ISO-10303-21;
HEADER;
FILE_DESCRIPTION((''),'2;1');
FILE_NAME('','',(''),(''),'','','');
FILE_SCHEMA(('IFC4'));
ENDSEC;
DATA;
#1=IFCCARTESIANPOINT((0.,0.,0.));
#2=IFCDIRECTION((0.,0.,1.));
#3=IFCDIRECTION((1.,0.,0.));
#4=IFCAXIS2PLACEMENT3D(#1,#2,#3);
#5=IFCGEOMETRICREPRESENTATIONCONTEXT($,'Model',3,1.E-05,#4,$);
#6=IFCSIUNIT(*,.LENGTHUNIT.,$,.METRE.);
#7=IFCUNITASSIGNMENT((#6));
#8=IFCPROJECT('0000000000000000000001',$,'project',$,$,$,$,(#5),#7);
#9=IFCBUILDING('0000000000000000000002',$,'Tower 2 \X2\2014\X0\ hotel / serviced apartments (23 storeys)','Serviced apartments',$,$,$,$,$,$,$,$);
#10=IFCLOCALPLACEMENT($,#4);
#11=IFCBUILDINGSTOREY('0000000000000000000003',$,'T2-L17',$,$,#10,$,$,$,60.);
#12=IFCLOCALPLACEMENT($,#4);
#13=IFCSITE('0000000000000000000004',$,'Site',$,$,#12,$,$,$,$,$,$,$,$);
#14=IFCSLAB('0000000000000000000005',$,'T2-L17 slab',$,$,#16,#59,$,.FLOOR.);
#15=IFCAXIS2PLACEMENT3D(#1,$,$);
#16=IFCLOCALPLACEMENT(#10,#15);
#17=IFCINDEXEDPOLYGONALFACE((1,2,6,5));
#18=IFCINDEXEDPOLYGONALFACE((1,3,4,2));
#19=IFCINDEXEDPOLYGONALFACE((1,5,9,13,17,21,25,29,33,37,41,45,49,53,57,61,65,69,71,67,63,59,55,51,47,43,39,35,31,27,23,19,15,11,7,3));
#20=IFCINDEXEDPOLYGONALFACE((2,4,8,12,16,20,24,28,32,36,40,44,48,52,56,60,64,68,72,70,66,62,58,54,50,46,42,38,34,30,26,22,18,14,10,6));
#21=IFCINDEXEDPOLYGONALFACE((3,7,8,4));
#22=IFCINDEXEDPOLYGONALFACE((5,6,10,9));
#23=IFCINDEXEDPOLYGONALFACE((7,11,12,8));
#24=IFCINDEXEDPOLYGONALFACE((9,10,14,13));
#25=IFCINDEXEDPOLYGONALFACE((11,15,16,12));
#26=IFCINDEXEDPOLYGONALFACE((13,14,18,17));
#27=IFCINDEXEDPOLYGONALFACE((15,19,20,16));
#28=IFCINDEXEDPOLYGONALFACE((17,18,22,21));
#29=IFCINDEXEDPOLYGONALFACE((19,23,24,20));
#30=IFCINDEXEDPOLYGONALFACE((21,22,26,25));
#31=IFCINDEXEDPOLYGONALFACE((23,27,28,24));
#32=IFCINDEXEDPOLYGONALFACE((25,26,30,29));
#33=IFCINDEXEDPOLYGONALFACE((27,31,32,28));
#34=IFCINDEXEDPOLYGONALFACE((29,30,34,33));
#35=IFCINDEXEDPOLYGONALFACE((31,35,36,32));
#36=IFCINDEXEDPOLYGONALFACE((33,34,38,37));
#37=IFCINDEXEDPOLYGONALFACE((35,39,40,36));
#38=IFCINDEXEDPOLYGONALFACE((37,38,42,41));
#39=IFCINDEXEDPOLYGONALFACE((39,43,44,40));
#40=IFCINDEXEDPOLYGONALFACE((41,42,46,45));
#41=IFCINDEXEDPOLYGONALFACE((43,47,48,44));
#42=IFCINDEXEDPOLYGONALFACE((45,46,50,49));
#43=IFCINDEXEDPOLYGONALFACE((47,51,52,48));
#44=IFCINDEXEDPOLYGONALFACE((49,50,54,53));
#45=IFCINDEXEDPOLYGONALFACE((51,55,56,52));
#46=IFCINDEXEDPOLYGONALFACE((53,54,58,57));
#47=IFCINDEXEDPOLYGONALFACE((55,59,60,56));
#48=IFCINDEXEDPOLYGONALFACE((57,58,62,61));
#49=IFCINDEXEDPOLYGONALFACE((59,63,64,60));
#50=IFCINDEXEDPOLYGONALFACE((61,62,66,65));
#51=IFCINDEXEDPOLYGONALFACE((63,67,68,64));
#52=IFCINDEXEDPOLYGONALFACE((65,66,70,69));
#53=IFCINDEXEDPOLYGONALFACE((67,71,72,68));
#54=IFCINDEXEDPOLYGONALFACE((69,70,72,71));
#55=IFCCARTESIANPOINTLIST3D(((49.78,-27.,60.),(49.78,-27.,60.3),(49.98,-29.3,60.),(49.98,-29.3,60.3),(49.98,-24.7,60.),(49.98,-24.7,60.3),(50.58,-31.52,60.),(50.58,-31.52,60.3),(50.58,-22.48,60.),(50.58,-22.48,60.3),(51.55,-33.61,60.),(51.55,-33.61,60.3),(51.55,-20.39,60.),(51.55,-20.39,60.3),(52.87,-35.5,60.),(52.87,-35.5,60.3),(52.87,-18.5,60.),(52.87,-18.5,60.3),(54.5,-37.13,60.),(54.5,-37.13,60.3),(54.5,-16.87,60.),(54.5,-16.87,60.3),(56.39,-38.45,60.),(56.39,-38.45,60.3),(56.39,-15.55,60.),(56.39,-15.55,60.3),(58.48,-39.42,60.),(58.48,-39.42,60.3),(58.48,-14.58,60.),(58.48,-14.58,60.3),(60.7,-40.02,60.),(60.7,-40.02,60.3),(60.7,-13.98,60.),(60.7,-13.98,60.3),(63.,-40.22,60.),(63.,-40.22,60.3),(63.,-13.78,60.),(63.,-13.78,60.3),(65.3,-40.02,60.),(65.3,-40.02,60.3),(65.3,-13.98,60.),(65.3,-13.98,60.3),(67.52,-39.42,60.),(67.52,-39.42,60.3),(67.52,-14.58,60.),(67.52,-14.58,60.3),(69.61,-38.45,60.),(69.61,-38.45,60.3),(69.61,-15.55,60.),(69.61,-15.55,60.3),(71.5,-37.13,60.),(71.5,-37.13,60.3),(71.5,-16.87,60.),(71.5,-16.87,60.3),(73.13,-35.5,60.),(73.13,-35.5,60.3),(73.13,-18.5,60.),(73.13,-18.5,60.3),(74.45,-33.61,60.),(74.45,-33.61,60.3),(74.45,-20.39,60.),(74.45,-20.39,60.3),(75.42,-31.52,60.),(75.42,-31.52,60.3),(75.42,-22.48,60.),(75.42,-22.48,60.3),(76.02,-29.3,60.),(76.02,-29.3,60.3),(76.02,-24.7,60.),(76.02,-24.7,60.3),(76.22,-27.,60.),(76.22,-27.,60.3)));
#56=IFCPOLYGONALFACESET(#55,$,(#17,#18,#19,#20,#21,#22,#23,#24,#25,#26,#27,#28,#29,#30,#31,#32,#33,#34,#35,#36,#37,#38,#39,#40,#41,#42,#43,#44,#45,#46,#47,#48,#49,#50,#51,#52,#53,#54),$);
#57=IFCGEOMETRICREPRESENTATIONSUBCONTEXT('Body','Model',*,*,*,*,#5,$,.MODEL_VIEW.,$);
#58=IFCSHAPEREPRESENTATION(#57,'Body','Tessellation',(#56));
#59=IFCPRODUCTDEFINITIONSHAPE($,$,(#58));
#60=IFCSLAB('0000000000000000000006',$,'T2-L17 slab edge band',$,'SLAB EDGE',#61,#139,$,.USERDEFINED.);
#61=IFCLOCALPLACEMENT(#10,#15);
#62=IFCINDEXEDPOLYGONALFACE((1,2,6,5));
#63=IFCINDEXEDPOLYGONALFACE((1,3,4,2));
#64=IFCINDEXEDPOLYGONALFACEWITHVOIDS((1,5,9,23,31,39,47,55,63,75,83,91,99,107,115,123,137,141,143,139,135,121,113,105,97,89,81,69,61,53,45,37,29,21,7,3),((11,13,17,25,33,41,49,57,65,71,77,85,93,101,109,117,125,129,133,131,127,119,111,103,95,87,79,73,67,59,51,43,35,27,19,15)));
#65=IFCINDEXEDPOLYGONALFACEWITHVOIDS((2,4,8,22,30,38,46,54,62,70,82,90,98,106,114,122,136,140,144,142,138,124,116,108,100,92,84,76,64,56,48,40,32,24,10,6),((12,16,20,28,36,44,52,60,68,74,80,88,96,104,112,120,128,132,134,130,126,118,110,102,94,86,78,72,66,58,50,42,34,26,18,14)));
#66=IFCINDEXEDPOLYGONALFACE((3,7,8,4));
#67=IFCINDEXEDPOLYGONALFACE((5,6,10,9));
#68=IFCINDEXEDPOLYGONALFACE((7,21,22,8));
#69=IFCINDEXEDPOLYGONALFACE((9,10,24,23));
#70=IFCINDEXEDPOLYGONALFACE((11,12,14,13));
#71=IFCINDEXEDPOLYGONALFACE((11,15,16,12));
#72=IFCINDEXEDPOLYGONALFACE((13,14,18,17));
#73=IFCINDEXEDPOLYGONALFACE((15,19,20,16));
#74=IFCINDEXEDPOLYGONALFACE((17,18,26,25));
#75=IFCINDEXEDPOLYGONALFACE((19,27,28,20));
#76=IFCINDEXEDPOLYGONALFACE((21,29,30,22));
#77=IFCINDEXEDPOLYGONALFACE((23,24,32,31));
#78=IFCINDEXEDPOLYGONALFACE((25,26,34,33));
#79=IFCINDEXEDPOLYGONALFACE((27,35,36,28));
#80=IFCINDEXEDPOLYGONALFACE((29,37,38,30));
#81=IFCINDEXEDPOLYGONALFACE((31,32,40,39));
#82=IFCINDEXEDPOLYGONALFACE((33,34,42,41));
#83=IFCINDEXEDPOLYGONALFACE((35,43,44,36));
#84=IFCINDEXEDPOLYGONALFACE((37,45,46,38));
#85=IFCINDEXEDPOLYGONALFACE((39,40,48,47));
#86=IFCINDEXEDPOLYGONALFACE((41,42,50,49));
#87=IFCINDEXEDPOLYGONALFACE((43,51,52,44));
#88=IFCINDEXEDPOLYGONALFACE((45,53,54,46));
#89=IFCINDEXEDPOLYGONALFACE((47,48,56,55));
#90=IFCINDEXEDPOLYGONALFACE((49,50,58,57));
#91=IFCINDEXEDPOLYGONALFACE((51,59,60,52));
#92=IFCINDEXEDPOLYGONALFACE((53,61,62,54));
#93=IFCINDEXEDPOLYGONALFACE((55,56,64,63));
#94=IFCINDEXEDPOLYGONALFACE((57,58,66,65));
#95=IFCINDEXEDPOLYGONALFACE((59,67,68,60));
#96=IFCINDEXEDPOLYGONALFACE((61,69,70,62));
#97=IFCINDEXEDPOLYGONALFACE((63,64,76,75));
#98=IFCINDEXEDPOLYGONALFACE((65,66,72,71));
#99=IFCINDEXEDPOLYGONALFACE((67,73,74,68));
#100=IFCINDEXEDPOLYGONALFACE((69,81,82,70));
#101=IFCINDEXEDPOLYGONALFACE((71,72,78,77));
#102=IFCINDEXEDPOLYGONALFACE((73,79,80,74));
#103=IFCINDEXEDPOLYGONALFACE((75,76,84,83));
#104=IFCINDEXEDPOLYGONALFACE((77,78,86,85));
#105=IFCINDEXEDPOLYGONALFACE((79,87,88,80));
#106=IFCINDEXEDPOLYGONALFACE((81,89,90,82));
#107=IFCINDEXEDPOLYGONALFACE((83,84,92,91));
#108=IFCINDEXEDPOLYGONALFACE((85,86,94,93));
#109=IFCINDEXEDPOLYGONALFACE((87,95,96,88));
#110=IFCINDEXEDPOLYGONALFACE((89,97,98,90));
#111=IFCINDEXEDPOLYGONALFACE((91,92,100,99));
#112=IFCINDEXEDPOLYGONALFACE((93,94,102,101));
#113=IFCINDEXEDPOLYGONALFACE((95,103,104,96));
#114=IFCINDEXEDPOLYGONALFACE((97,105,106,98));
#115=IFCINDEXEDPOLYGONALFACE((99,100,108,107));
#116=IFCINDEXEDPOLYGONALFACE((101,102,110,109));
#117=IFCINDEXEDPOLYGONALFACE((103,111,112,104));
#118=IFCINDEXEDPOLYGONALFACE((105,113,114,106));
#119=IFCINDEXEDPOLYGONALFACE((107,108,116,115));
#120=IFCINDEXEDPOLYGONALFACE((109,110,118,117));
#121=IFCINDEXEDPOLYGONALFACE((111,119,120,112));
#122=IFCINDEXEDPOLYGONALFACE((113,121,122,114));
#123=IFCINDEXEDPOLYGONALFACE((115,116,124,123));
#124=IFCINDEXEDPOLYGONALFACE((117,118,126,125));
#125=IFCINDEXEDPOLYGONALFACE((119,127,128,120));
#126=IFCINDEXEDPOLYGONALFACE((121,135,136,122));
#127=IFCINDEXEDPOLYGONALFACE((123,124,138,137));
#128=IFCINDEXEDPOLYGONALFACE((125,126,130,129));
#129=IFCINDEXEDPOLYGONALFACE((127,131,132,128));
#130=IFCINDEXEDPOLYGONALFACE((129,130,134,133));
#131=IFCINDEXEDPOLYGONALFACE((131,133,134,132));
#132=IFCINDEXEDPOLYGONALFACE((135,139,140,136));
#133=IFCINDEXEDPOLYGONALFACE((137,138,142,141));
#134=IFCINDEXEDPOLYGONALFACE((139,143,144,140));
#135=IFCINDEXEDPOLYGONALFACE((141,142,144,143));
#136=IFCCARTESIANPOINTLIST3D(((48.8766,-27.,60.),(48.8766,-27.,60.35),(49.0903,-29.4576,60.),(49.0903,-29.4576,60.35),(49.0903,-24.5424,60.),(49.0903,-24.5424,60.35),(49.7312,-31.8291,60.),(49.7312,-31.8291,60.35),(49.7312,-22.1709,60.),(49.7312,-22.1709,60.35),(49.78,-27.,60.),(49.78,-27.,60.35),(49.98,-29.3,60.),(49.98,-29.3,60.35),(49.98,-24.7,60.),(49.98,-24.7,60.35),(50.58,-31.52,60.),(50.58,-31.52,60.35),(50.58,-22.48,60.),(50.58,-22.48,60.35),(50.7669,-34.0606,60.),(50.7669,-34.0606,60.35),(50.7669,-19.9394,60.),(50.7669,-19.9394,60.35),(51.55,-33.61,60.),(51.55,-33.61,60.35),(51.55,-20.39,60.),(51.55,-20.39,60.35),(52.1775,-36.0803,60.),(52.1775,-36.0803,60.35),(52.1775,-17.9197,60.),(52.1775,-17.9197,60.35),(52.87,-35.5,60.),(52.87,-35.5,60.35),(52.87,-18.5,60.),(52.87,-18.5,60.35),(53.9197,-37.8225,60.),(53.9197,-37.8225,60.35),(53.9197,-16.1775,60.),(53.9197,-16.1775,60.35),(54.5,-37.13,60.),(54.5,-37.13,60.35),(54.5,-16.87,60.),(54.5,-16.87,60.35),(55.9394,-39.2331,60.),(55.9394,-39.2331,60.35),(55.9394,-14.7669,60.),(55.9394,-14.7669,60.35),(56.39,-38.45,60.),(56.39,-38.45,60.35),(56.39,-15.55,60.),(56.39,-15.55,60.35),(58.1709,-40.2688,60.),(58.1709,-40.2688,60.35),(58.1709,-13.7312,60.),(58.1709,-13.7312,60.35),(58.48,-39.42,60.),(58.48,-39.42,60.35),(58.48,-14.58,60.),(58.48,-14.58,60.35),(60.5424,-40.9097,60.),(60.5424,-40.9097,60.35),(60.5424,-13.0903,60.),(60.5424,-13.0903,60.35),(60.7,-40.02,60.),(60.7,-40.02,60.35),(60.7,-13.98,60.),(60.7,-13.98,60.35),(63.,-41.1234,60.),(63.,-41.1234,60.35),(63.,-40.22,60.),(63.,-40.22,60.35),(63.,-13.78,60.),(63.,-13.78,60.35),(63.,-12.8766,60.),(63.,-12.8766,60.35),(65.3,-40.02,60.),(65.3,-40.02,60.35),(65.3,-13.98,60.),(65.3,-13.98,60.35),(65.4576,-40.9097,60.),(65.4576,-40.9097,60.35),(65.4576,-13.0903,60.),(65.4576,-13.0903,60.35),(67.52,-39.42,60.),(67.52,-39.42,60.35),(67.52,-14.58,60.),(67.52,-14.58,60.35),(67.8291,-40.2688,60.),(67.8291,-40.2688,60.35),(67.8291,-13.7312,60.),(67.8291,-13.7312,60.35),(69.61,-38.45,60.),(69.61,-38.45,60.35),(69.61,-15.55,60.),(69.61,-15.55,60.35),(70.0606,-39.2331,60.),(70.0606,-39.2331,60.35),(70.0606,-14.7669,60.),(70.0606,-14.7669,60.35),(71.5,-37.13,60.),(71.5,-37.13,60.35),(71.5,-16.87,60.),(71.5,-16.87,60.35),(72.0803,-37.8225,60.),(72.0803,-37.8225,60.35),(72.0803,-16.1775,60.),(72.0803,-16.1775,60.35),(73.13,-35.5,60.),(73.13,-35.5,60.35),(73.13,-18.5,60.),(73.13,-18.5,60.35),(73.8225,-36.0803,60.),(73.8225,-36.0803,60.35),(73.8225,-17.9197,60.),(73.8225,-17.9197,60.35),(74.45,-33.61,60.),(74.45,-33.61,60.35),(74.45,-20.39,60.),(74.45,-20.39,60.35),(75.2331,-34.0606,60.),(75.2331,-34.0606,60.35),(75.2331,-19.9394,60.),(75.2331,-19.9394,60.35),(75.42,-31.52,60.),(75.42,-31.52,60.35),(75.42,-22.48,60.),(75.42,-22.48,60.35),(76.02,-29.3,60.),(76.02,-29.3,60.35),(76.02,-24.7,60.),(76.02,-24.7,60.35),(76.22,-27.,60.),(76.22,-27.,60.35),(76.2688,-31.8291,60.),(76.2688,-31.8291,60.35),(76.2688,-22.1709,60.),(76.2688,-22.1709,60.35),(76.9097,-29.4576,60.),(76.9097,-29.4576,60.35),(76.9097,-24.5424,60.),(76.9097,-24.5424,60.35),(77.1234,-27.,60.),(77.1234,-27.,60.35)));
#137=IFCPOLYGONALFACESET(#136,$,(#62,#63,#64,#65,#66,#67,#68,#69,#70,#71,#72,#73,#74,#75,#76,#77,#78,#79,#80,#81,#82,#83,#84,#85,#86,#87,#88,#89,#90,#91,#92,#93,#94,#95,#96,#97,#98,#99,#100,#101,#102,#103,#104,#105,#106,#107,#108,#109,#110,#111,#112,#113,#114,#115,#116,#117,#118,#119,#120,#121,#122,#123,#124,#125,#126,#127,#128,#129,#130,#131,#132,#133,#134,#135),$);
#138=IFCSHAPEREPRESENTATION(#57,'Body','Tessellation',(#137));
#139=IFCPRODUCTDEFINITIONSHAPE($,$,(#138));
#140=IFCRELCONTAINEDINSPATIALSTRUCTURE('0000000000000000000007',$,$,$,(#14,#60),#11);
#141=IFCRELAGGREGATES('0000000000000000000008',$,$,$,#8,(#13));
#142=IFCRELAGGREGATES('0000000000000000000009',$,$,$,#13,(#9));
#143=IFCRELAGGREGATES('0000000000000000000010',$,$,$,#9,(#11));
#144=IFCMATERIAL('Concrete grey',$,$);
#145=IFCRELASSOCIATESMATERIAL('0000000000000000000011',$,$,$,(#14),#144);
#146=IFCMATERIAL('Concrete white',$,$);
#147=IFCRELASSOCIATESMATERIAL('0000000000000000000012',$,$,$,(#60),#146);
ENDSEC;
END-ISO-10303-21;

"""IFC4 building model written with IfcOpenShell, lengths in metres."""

from ifc_helpers import new_model, si_unit, frame, origin_with_axes, place, context, subcontext, project, spatial, polyline, outline, extrude, material, element, save


model = new_model("IFC4")

# Units and contexts
model_context = context("Model", 3, precision=1e-05, world=origin_with_axes())
body_context = subcontext(model_context, "Body", "Model", "MODEL_VIEW")
ifc_project = project(units=[si_unit("LENGTHUNIT", "METRE")], contexts=[model_context])

# Site, building, storey
site_placement = place(None, origin_with_axes())
site = spatial("IfcSite", under=ifc_project, at=site_placement, Name="Site")
building = spatial("IfcBuilding", under=site, Name="Tower 2 — hotel / serviced apartments (23 storeys)", Description="Serviced apartments")
storey_placement = place(None, origin_with_axes())
storey = spatial("IfcBuildingStorey", under=building, at=storey_placement, Name="T2-L17", Elevation=60.0)

# Slab
ifc_material_1 = material(Name="Concrete grey")
slab_1_placement = place(storey_placement, origin_with_axes())
element("IfcSlab", 1, at=slab_1_placement, inside=storey, material=ifc_material_1, Name="T2-L17 slab", PredefinedType="FLOOR", context=body_context, shape_type="SweptSolid", body=[
    extrude(outline(polyline([(76.22, -27.0), (76.02, -24.7), (75.42, -22.48), (74.45, -20.39), (73.13, -18.5), (71.5, -16.87), (69.61, -15.55), (67.52, -14.58), (65.3, -13.98), (63.0, -13.78), (60.7, -13.98), (58.48, -14.58), (56.39, -15.55), (54.5, -16.87), (52.87, -18.5), (51.55, -20.39), (50.58, -22.48), (49.98, -24.7), (49.78, -27.0), (49.98, -29.3), (50.58, -31.52), (51.55, -33.61), (52.87, -35.5), (54.5, -37.13), (56.39, -38.45), (58.48, -39.42), (60.7, -40.02), (63.0, -40.22), (65.3, -40.02), (67.52, -39.42), (69.61, -38.45), (71.5, -37.13), (73.13, -35.5), (74.45, -33.61), (75.42, -31.52), (76.02, -29.3), (76.22, -27.0)])), frame((0.0, 0.0, 60.0), z_axis=(0.0, 0.0, 1.0), x_axis=(1.0, 0.0, 0.0)), (0.0, 0.0, 1.0), 0.3),
])

# Slab
ifc_material_2 = material(Name="Concrete white")
slab_2_placement = place(storey_placement, origin_with_axes())
element("IfcSlab", 2, at=slab_2_placement, inside=storey, material=ifc_material_2, Name="T2-L17 slab edge band", ObjectType="SLAB EDGE", PredefinedType="USERDEFINED", context=body_context, shape_type="SweptSolid", body=[
    extrude(outline(polyline([(77.1234, -27.0), (76.9097, -24.5424), (76.2688, -22.1709), (75.2331, -19.9394), (73.8225, -17.9197), (72.0803, -16.1775), (70.0606, -14.7669), (67.8291, -13.7312), (65.4576, -13.0903), (63.0, -12.8766), (60.5424, -13.0903), (58.1709, -13.7312), (55.9394, -14.7669), (53.9197, -16.1775), (52.1775, -17.9197), (50.7669, -19.9394), (49.7312, -22.1709), (49.0903, -24.5424), (48.8766, -27.0), (49.0903, -29.4576), (49.7312, -31.8291), (50.7669, -34.0606), (52.1775, -36.0803), (53.9197, -37.8225), (55.9394, -39.2331), (58.1709, -40.2688), (60.5424, -40.9097), (63.0, -41.1234), (65.4576, -40.9097), (67.8291, -40.2688), (70.0606, -39.2331), (72.0803, -37.8225), (73.8225, -36.0803), (75.2331, -34.0606), (76.2688, -31.8291), (76.9097, -29.4576), (77.1234, -27.0)]), holes=[polyline([(76.22, -27.0), (76.02, -24.7), (75.42, -22.48), (74.45, -20.39), (73.13, -18.5), (71.5, -16.87), (69.61, -15.55), (67.52, -14.58), (65.3, -13.98), (63.0, -13.78), (60.7, -13.98), (58.48, -14.58), (56.39, -15.55), (54.5, -16.87), (52.87, -18.5), (51.55, -20.39), (50.58, -22.48), (49.98, -24.7), (49.78, -27.0), (49.98, -29.3), (50.58, -31.52), (51.55, -33.61), (52.87, -35.5), (54.5, -37.13), (56.39, -38.45), (58.48, -39.42), (60.7, -40.02), (63.0, -40.22), (65.3, -40.02), (67.52, -39.42), (69.61, -38.45), (71.5, -37.13), (73.13, -35.5), (74.45, -33.61), (75.42, -31.52), (76.02, -29.3), (76.22, -27.0)])]), frame((0.0, 0.0, 60.0), z_axis=(0.0, 0.0, 1.0), x_axis=(1.0, 0.0, 0.0)), (0.0, 0.0, 1.0), 0.35),
])

save(model, "model.ifc")
